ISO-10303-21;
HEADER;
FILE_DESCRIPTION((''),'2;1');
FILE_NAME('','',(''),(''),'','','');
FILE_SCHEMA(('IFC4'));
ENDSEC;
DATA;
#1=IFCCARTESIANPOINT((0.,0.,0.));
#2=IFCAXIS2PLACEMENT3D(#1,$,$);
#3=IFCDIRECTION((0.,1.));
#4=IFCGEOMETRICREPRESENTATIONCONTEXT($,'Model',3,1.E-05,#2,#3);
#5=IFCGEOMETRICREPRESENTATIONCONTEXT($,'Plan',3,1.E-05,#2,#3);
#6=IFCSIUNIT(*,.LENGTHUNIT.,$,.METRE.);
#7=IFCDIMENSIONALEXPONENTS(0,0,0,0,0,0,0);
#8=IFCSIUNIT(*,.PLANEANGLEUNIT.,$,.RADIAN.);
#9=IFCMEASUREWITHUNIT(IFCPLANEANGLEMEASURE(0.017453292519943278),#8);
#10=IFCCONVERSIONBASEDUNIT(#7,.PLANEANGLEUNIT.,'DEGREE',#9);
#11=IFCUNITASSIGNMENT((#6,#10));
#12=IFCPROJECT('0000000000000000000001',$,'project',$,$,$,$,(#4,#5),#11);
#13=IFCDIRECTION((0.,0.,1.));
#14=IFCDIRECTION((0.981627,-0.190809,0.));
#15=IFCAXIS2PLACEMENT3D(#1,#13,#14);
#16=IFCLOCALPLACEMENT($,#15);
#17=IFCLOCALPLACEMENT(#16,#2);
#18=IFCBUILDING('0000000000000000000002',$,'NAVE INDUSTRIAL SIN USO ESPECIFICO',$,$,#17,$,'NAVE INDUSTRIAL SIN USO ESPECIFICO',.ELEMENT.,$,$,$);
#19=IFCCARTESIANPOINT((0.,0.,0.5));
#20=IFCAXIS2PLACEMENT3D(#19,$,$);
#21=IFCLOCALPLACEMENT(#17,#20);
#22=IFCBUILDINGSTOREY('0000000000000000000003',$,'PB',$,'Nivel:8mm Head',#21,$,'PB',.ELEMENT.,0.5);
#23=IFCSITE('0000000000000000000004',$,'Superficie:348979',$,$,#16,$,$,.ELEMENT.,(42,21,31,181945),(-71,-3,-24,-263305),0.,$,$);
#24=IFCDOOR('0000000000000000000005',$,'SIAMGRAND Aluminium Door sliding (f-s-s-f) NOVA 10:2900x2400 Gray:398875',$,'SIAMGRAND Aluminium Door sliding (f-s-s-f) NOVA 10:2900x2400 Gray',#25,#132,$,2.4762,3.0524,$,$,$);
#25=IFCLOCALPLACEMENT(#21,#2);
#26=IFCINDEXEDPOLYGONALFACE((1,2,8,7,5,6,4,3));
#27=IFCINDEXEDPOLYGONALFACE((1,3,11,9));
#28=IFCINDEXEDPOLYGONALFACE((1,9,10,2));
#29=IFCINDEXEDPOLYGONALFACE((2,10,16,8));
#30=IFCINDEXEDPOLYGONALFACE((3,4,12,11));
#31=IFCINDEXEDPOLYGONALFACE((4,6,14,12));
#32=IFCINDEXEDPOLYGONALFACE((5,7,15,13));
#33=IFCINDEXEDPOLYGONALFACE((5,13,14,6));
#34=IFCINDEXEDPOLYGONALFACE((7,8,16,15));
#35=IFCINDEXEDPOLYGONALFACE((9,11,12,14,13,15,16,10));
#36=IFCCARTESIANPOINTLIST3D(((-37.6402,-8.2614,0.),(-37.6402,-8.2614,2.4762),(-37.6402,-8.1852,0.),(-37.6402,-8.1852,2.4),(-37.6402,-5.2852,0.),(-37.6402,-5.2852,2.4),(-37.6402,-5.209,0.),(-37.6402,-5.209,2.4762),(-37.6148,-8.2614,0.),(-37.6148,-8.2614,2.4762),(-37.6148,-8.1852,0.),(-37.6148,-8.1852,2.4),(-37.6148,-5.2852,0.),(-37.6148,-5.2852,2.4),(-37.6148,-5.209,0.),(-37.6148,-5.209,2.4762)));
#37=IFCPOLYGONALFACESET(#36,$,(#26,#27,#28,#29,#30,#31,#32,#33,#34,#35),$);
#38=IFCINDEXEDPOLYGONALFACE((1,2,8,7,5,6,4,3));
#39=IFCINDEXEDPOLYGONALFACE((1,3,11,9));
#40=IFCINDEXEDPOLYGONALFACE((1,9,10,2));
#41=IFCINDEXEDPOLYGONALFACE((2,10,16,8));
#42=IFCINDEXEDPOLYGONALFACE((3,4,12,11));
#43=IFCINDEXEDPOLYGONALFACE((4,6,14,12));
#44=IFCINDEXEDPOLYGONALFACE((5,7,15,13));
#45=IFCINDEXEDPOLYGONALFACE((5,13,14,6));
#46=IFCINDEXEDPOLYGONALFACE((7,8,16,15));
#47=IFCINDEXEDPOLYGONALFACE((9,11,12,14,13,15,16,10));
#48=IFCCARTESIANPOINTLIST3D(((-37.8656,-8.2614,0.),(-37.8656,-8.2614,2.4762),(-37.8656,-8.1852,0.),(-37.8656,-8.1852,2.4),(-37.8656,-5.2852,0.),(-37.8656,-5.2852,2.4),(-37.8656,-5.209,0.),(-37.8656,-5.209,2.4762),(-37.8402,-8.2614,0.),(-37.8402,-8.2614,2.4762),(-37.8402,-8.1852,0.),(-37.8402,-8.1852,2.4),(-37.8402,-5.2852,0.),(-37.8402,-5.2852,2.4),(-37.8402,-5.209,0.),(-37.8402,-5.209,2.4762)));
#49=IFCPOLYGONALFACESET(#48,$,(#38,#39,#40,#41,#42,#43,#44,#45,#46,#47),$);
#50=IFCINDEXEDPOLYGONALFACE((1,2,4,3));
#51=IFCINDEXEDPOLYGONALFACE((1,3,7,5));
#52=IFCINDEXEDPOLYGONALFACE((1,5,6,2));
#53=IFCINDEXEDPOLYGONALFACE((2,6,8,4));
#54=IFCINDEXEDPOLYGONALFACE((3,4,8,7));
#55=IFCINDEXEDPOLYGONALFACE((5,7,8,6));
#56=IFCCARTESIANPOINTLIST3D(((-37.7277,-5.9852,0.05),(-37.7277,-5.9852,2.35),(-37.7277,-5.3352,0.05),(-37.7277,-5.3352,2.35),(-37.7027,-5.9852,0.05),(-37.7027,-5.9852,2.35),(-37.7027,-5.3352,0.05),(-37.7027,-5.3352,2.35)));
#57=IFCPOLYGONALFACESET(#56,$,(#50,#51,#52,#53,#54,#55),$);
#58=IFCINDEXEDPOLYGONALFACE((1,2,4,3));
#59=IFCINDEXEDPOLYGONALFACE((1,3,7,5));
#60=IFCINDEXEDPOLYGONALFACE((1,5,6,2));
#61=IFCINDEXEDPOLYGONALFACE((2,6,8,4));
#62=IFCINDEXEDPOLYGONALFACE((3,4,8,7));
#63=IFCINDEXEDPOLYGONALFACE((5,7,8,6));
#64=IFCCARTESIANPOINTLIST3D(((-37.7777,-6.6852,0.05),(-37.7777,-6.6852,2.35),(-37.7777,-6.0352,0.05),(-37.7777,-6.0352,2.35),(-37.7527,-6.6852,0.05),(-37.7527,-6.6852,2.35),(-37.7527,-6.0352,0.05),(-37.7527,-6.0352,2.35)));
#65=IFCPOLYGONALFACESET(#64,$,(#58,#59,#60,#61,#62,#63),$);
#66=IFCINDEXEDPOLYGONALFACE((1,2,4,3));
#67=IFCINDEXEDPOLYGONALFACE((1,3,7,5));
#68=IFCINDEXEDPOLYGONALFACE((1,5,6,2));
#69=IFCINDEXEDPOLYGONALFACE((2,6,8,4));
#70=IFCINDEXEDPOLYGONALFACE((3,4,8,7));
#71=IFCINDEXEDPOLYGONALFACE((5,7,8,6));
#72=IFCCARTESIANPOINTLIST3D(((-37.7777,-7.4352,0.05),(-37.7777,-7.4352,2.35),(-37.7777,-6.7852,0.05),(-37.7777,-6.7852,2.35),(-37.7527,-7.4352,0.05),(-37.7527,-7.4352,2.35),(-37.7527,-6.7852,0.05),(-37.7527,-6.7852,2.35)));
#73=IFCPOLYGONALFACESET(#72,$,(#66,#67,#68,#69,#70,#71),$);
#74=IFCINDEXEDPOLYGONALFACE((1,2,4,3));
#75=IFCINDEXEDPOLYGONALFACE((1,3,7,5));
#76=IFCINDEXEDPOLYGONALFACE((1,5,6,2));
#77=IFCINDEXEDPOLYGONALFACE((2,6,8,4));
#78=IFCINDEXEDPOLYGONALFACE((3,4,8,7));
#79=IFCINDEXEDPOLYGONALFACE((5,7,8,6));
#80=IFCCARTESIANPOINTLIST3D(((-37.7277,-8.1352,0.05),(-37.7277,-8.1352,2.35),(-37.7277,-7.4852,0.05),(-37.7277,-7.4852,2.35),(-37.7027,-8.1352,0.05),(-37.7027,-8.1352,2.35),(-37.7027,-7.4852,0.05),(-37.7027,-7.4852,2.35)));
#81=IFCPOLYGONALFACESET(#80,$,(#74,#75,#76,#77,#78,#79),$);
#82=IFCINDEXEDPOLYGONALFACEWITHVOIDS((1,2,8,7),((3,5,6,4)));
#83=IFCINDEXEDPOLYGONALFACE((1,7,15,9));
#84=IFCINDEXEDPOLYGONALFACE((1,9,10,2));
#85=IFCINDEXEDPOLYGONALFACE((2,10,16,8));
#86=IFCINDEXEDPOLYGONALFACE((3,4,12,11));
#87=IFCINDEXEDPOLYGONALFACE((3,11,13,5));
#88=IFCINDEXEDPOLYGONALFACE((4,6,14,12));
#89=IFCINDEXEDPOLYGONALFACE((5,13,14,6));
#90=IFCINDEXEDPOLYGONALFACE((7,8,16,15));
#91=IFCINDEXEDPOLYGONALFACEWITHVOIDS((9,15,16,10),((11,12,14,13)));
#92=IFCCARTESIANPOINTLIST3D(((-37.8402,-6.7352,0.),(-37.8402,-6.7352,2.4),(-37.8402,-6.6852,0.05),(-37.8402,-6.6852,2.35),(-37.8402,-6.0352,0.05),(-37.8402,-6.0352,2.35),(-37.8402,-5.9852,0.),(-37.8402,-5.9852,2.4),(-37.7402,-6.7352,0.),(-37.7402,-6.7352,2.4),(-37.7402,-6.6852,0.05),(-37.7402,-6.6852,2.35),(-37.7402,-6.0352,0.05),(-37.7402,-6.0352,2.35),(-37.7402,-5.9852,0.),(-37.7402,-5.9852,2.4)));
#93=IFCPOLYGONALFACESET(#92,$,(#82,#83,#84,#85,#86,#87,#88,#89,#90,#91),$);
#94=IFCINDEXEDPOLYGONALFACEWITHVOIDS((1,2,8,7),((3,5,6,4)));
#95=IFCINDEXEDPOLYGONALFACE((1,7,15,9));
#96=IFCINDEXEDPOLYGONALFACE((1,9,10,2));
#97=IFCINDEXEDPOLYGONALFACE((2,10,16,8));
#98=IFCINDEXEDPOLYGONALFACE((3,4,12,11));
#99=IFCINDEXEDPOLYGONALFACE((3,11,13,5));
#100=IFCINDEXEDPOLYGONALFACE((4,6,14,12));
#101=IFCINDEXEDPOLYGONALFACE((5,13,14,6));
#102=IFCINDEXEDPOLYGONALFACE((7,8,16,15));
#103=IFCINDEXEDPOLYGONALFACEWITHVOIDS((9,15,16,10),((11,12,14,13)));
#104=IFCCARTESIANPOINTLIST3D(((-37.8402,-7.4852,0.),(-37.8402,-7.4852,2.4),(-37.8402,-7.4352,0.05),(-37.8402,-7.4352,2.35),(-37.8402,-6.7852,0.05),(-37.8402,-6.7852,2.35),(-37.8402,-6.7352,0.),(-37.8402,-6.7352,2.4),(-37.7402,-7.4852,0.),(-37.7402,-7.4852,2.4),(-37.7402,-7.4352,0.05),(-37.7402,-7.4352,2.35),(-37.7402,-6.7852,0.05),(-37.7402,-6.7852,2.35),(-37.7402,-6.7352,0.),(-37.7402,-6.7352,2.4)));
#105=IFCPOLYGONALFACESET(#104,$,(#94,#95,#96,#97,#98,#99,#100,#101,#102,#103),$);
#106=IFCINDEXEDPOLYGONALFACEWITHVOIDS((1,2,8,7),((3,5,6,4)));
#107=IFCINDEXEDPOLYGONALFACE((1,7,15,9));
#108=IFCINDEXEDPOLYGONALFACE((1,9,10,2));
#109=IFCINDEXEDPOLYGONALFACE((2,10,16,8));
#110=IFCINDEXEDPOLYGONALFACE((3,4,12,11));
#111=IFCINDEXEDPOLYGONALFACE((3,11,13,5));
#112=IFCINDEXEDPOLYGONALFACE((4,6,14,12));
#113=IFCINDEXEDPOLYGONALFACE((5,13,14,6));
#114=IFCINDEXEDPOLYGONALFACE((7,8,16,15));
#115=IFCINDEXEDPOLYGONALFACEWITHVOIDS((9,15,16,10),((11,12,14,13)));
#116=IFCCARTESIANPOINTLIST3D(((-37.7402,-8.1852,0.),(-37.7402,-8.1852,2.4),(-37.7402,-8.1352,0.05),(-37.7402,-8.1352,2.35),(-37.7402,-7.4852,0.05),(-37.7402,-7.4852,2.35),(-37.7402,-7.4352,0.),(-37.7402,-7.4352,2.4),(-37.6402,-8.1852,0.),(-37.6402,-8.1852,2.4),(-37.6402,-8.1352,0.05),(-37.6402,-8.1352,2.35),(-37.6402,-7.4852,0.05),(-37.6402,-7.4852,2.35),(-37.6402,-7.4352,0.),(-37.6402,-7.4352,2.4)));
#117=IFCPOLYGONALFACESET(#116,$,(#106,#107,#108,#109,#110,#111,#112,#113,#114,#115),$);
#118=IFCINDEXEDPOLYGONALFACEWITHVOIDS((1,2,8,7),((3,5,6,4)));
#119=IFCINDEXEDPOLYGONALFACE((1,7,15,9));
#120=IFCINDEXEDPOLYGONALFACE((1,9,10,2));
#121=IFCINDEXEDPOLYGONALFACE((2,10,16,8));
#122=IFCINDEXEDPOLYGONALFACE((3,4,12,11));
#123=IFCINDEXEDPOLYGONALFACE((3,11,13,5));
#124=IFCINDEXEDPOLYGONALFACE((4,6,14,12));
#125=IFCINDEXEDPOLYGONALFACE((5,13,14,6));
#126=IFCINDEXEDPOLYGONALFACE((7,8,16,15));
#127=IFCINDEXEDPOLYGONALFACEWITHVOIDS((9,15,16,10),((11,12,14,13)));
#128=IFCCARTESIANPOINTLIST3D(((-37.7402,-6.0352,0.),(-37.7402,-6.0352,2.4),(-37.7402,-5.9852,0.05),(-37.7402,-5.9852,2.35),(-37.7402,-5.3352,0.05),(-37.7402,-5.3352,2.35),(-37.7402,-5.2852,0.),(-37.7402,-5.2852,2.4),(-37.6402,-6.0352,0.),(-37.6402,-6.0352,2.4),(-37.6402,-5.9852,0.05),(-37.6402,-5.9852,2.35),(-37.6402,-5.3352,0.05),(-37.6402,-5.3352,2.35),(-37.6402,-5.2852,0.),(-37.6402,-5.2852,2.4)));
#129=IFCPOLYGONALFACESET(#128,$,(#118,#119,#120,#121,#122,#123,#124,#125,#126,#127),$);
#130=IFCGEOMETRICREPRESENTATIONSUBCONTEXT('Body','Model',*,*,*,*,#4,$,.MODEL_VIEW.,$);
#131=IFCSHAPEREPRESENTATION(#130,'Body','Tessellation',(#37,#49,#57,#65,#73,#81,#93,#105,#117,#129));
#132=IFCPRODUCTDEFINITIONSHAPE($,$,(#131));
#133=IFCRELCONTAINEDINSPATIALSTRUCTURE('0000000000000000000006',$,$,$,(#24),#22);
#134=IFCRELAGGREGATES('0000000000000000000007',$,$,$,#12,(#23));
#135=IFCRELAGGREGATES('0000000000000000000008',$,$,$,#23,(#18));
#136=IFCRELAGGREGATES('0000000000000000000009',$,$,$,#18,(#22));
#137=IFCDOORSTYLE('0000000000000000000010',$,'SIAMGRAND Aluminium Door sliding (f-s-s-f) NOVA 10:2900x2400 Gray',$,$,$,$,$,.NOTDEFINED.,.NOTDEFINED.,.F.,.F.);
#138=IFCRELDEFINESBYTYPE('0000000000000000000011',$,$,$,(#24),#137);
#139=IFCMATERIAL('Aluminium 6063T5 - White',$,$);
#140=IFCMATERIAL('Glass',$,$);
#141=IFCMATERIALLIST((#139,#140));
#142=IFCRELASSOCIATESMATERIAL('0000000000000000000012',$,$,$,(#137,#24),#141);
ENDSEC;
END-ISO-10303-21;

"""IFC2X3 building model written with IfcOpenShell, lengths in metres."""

from ifc_helpers import new_model, entity, si_unit, converted_unit, direction, frame, frame_2d, origin, place, context, subcontext, project, spatial, polyline, rectangle, outline, extrude, source, transform, mapped, material, material_list, type_object, type_shapes, element, save


model = new_model("IFC2X3")

# Units and contexts
model_context = context("Model", 3, precision=1e-05, world=origin(), true_north=direction((0.0, 1.0)))
plan_context = context("Plan", 3, precision=1e-05, world=origin(), true_north=direction((0.0, 1.0)))
body_context = subcontext(model_context, "Body", "Model", "MODEL_VIEW")
ifc_project = project(units=[si_unit("LENGTHUNIT", "METRE"), converted_unit("PLANEANGLEUNIT", "DEGREE", entity("IfcPlaneAngleMeasure", 0.017453292519943278), si_unit("PLANEANGLEUNIT", "RADIAN"), dimensions=[0, 0, 0, 0, 0, 0, 0])], contexts=[model_context, plan_context])

# Site, building, storey
site_placement = place(None, frame((0.0, 0.0, 0.0), z_axis=(0.0, 0.0, 1.0), x_axis=(0.981627, -0.190809, 0.0)))
site = spatial("IfcSite", under=ifc_project, at=site_placement, Name="Superficie:348979", CompositionType="ELEMENT", RefLatitude=(42, 21, 31, 181945), RefLongitude=(-71, -3, -24, -263305), RefElevation=0.0)
building_placement = place(site_placement, origin())
building = spatial("IfcBuilding", under=site, at=building_placement, Name="NAVE INDUSTRIAL SIN USO ESPECIFICO", LongName="NAVE INDUSTRIAL SIN USO ESPECIFICO", CompositionType="ELEMENT")
storey_placement = place(building_placement, frame((0.0, 0.0, 0.5)))
storey = spatial("IfcBuildingStorey", under=building, at=storey_placement, Name="PB", ObjectType="Nivel:8mm Head", LongName="PB", CompositionType="ELEMENT", Elevation=0.5)

# Shared definitions
ifc_material_1 = material(Name="Glass")

# Door
ifc_material_2 = material(Name="Aluminium 6063T5 - White")
ifc_material_list = material_list([ifc_material_2, ifc_material_1])
door_style_1 = type_object("IfcDoorStyle", Name="SIAMGRAND Aluminium Door sliding (f-s-s-f) NOVA 10:2900x2400 Gray", ConstructionType="NOTDEFINED", OperationType="NOTDEFINED", ParameterTakesPrecedence=False, Sizeable=False, material=ifc_material_list)
shared_shape_1 = source(origin(), body_context, "Body", "SweptSolid", [
    extrude(outline(polyline([(-1.1809, 1.45), (1.2191, 1.45), (1.219, 1.5262), (-1.2571, 1.5262), (-1.2571, -1.5262), (1.219, -1.5262), (1.219, -1.45), (-1.1809, -1.45), (-1.1809, 1.45)])), frame((1.45, 0.0, 1.219), z_axis=(0.0, -1.0, 0.0), x_axis=(0.0, 0.0, -1.0)), (0.0, 0.0, 1.0), 0.0254),
    extrude(outline(polyline([(-1.1809, 1.45), (1.219, 1.45), (1.219, 1.5262), (-1.2571, 1.5262), (-1.2571, -1.5262), (1.219, -1.5262), (1.219, -1.45), (-1.1809, -1.45), (-1.1809, 1.45)])), frame((1.45, 0.2254, 1.219), z_axis=(0.0, -1.0, 0.0), x_axis=(0.0, 0.0, -1.0)), (0.0, 0.0, 1.0), 0.0254),
    extrude(rectangle(XDim=0.65, YDim=0.025, at=frame_2d((0.0, 0.0), x_axis=(1.0, 0.0))), frame((2.525, 0.075, 0.05)), (0.0, 0.0, 1.0), 2.3),
    extrude(rectangle(XDim=0.65, YDim=0.025, at=frame_2d((0.0, 0.0), x_axis=(1.0, 0.0))), frame((1.825, 0.125, 0.05)), (0.0, 0.0, 1.0), 2.3),
    extrude(rectangle(XDim=0.65, YDim=0.025, at=frame_2d((0.0, 0.0), x_axis=(1.0, 0.0))), frame((1.075, 0.125, 0.05)), (0.0, 0.0, 1.0), 2.3),
    extrude(rectangle(XDim=0.65, YDim=0.025, at=frame_2d((0.0, 0.0), x_axis=(1.0, 0.0))), frame((0.375, 0.075, 0.05)), (0.0, 0.0, 1.0), 2.3),
    extrude(outline(polyline([(-0.375, -1.2), (0.375, -1.2), (0.375, 1.2), (-0.375, 1.2), (-0.375, -1.2)]), holes=[polyline([(-0.325, -1.15), (-0.325, 1.15), (0.325, 1.15), (0.325, -1.15), (-0.325, -1.15)])]), frame((1.825, 0.2, 1.2), z_axis=(0.0, -1.0, 0.0), x_axis=(-1.0, 0.0, 0.0)), (0.0, 0.0, 1.0), 0.1),
    extrude(outline(polyline([(-0.375, -1.2), (0.375, -1.2), (0.375, 1.2), (-0.375, 1.2), (-0.375, -1.2)]), holes=[polyline([(-0.325, -1.15), (-0.325, 1.15), (0.325, 1.15), (0.325, -1.15), (-0.325, -1.15)])]), frame((1.075, 0.2, 1.2), z_axis=(0.0, -1.0, 0.0), x_axis=(-1.0, 0.0, 0.0)), (0.0, 0.0, 1.0), 0.1),
    extrude(outline(polyline([(-0.375, -1.2), (0.375, -1.2), (0.375, 1.2), (-0.375, 1.2), (-0.375, -1.2)]), holes=[polyline([(-0.325, -1.15), (-0.325, 1.15), (0.325, 1.15), (0.325, -1.15), (-0.325, -1.15)])]), frame((0.375, 0.1, 1.2), z_axis=(0.0, -1.0, 0.0), x_axis=(-1.0, 0.0, 0.0)), (0.0, 0.0, 1.0), 0.1),
    extrude(outline(polyline([(-0.375, -1.2), (0.375, -1.2), (0.375, 1.2), (-0.375, 1.2), (-0.375, -1.2)]), holes=[polyline([(-0.325, -1.15), (-0.325, 1.15), (0.325, 1.15), (0.325, -1.15), (-0.325, -1.15)])]), frame((2.525, 0.1, 1.2), z_axis=(0.0, -1.0, 0.0), x_axis=(-1.0, 0.0, 0.0)), (0.0, 0.0, 1.0), 0.1),
])
type_shapes(door_style_1, [shared_shape_1])
door_1_placement = place(storey_placement, frame((-37.6402, -8.1852, 0.0), z_axis=(0.0, 0.0, 1.0), x_axis=(0.0, 1.0, 0.0)))
element("IfcDoor", 1, at=door_1_placement, inside=storey, type_object=door_style_1, material=ifc_material_list, Name="SIAMGRAND Aluminium Door sliding (f-s-s-f) NOVA 10:2900x2400 Gray:398875", ObjectType="SIAMGRAND Aluminium Door sliding (f-s-s-f) NOVA 10:2900x2400 Gray", OverallHeight=2.4762, OverallWidth=3.0524, context=body_context, shape_type="MappedRepresentation", body=[
    mapped(shared_shape_1, transform((0.0, 0.0, 0.0), scale=1.0)),
])

save(model, "model.ifc")
